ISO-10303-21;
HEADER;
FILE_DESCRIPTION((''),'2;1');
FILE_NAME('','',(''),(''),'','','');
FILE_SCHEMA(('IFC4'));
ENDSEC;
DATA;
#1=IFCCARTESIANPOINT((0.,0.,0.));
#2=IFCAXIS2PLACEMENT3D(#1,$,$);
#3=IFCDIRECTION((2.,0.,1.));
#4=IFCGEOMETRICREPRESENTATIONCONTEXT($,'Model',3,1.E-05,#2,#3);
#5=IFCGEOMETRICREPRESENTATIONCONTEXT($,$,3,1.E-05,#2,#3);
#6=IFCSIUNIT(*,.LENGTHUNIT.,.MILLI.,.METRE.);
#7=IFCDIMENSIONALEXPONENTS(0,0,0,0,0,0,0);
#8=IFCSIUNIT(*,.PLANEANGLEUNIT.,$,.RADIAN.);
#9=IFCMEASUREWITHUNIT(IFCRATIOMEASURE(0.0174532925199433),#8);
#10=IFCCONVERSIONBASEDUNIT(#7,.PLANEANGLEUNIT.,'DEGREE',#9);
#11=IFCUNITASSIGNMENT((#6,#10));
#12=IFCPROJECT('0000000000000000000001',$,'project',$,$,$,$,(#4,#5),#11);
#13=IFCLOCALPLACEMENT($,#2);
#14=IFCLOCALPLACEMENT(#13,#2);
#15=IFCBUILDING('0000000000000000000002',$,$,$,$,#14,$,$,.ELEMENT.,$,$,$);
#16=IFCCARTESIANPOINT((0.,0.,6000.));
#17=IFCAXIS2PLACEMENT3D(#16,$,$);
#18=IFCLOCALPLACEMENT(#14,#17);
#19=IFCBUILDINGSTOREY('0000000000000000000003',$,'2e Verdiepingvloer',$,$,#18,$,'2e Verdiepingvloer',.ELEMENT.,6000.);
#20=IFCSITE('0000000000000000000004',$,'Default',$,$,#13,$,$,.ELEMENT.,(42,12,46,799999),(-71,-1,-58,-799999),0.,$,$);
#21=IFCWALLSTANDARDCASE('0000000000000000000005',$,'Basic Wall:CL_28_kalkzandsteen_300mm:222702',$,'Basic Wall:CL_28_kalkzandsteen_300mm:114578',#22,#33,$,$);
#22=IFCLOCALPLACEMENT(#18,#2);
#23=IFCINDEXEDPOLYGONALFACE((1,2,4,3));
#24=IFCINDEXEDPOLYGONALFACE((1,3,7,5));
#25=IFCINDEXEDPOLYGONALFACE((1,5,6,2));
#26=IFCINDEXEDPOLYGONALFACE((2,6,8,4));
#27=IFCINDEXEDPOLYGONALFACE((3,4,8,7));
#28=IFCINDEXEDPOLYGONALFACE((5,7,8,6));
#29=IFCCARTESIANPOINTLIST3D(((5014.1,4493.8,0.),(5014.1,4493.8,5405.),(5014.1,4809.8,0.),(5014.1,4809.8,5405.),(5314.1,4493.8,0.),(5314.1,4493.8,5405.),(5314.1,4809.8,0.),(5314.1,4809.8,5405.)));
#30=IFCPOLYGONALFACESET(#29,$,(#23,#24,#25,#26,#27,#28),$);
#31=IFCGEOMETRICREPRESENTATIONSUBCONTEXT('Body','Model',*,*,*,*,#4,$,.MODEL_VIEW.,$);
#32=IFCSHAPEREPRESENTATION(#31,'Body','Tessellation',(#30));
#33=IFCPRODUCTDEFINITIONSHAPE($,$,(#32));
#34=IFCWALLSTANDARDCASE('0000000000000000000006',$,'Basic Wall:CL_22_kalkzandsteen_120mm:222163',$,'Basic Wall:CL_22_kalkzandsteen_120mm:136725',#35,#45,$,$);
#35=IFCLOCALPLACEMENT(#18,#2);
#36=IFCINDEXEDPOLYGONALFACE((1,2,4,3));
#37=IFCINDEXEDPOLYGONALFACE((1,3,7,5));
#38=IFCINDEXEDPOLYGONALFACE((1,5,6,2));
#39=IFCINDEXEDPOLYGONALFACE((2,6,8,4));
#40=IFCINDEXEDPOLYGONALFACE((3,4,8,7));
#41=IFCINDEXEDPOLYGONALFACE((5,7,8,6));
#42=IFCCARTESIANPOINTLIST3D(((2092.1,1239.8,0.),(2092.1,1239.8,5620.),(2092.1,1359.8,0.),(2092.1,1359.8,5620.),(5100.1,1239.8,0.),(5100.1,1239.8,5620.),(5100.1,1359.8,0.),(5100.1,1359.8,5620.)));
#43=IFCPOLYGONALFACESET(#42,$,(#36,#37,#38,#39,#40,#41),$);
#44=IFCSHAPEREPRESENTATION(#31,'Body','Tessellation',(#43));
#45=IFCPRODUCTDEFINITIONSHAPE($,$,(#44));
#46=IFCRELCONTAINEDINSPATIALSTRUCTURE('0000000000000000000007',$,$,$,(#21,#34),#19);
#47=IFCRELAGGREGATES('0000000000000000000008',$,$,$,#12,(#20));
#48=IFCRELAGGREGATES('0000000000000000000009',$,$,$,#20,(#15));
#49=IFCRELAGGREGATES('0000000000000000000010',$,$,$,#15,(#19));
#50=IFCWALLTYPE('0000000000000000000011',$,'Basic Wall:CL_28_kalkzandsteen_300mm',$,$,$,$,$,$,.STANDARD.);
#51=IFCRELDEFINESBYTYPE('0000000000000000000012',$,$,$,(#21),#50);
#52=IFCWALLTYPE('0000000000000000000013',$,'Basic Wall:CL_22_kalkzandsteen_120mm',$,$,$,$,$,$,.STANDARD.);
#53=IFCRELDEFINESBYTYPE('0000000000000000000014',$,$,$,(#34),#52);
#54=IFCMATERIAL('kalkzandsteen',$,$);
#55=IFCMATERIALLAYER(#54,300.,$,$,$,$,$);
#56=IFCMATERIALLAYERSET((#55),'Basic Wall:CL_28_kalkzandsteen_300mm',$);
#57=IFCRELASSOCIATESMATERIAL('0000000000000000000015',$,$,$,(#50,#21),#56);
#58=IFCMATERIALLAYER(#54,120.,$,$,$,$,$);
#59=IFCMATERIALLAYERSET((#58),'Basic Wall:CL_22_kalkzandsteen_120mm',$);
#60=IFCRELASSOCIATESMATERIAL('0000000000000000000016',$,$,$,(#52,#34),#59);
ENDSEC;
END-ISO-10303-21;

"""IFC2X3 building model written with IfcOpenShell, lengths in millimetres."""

from ifc_helpers import new_model, entity, si_unit, converted_unit, direction, frame, frame_2d, origin, place, context, subcontext, project, spatial, polyline, rectangle, extrude, clip, bounded_halfspace, material, layer, layer_set, layer_usage, type_object, element, save


model = new_model("IFC2X3")

# Units and contexts
model_context = context("Model", 3, precision=1e-05, world=origin(), true_north=direction((2.0, 0.0, 1.0)))
context_of_model = context(None, 3, precision=1e-05, world=origin(), true_north=direction((2.0, 0.0, 1.0)))
body_context = subcontext(model_context, "Body", "Model", "MODEL_VIEW")
ifc_project = project(units=[si_unit("LENGTHUNIT", "METRE", prefix="MILLI"), converted_unit("PLANEANGLEUNIT", "DEGREE", entity("IfcRatioMeasure", 0.0174532925199433), si_unit("PLANEANGLEUNIT", "RADIAN"), dimensions=[0, 0, 0, 0, 0, 0, 0])], contexts=[model_context, context_of_model])

# Site, building, storey
site_placement = place(None, origin())
site = spatial("IfcSite", under=ifc_project, at=site_placement, Name="Default", CompositionType="ELEMENT", RefLatitude=(42, 12, 46, 799999), RefLongitude=(-71, -1, -58, -799999), RefElevation=0.0)
building_placement = place(site_placement, origin())
building = spatial("IfcBuilding", under=site, at=building_placement, CompositionType="ELEMENT")
storey_placement = place(building_placement, frame((0.0, 0.0, 6000.0)))
storey = spatial("IfcBuildingStorey", under=building, at=storey_placement, Name="2e Verdiepingvloer", LongName="2e Verdiepingvloer", CompositionType="ELEMENT", Elevation=6000.0)

# Walls
ifc_material_1 = material(Name="kalkzandsteen")
ifc_layer_1 = layer(ifc_material_1, 300.0)
ifc_layer_set_1 = layer_set([ifc_layer_1], Name="Basic Wall:CL_28_kalkzandsteen_300mm")
ifc_layer_usage_1 = layer_usage(ifc_layer_set_1, "AXIS2", "NEGATIVE", 150.0)
wall_type_1 = type_object("IfcWallType", Name="Basic Wall:CL_28_kalkzandsteen_300mm", PredefinedType="STANDARD", material=ifc_layer_set_1)
wall_1_placement = place(storey_placement, frame((5164.1, 4493.8, 0.0), z_axis=(0.0, 0.0, 1.0), x_axis=(0.0, 1.0, 0.0)))
element("IfcWallStandardCase", 1, at=wall_1_placement, inside=storey, type_object=wall_type_1, material=ifc_layer_usage_1, Name="Basic Wall:CL_28_kalkzandsteen_300mm:222702", ObjectType="Basic Wall:CL_28_kalkzandsteen_300mm:114578", context=body_context, shape_type="Clipping", body=[
    clip(extrude(rectangle(XDim=316.0, YDim=300.0, at=frame_2d((158.0, 0.0), x_axis=(-1.0, 0.0))), origin(), (0.0, 0.0, 1.0), 5860.0), bounded_halfspace(frame((0.0, -150.0, 5405.0), z_axis=(0.0, 0.0, 1.0), x_axis=(0.0, -1.0, 0.0)), False, frame((0.0, -150.0, 5405.0)), polyline([(0.0, 0.0), (316.0, 0.0), (316.0, 300.0), (0.0, 300.0), (0.0, 0.0)]))),
])
ifc_layer_2 = layer(ifc_material_1, 120.0)
ifc_layer_set_2 = layer_set([ifc_layer_2], Name="Basic Wall:CL_22_kalkzandsteen_120mm")
ifc_layer_usage_2 = layer_usage(ifc_layer_set_2, "AXIS2", "NEGATIVE", 60.0)
wall_type_2 = type_object("IfcWallType", Name="Basic Wall:CL_22_kalkzandsteen_120mm", PredefinedType="STANDARD", material=ifc_layer_set_2)
wall_2_placement = place(storey_placement, frame((2092.1, 1299.8, 0.0)))
element("IfcWallStandardCase", 2, at=wall_2_placement, inside=storey, type_object=wall_type_2, material=ifc_layer_usage_2, Name="Basic Wall:CL_22_kalkzandsteen_120mm:222163", ObjectType="Basic Wall:CL_22_kalkzandsteen_120mm:136725", context=body_context, shape_type="Clipping", body=[
    clip(extrude(rectangle(XDim=3008.0, YDim=120.0, at=frame_2d((1504.0, 0.0), x_axis=(-1.0, 0.0))), origin(), (0.0, 0.0, 1.0), 5620.0), bounded_halfspace(frame((0.0, -60.0, 5620.0), z_axis=(0.0, 0.0, -1.0), x_axis=(0.0, -1.0, 0.0)), True, frame((0.0, -60.0, 5620.0)), polyline([(0.0, 0.0), (2922.0, 0.0), (3008.0, 0.0), (3008.0, 120.0), (14.0, 120.0), (0.0, 120.0), (0.0, 0.0)]))),
])

save(model, "model.ifc")
